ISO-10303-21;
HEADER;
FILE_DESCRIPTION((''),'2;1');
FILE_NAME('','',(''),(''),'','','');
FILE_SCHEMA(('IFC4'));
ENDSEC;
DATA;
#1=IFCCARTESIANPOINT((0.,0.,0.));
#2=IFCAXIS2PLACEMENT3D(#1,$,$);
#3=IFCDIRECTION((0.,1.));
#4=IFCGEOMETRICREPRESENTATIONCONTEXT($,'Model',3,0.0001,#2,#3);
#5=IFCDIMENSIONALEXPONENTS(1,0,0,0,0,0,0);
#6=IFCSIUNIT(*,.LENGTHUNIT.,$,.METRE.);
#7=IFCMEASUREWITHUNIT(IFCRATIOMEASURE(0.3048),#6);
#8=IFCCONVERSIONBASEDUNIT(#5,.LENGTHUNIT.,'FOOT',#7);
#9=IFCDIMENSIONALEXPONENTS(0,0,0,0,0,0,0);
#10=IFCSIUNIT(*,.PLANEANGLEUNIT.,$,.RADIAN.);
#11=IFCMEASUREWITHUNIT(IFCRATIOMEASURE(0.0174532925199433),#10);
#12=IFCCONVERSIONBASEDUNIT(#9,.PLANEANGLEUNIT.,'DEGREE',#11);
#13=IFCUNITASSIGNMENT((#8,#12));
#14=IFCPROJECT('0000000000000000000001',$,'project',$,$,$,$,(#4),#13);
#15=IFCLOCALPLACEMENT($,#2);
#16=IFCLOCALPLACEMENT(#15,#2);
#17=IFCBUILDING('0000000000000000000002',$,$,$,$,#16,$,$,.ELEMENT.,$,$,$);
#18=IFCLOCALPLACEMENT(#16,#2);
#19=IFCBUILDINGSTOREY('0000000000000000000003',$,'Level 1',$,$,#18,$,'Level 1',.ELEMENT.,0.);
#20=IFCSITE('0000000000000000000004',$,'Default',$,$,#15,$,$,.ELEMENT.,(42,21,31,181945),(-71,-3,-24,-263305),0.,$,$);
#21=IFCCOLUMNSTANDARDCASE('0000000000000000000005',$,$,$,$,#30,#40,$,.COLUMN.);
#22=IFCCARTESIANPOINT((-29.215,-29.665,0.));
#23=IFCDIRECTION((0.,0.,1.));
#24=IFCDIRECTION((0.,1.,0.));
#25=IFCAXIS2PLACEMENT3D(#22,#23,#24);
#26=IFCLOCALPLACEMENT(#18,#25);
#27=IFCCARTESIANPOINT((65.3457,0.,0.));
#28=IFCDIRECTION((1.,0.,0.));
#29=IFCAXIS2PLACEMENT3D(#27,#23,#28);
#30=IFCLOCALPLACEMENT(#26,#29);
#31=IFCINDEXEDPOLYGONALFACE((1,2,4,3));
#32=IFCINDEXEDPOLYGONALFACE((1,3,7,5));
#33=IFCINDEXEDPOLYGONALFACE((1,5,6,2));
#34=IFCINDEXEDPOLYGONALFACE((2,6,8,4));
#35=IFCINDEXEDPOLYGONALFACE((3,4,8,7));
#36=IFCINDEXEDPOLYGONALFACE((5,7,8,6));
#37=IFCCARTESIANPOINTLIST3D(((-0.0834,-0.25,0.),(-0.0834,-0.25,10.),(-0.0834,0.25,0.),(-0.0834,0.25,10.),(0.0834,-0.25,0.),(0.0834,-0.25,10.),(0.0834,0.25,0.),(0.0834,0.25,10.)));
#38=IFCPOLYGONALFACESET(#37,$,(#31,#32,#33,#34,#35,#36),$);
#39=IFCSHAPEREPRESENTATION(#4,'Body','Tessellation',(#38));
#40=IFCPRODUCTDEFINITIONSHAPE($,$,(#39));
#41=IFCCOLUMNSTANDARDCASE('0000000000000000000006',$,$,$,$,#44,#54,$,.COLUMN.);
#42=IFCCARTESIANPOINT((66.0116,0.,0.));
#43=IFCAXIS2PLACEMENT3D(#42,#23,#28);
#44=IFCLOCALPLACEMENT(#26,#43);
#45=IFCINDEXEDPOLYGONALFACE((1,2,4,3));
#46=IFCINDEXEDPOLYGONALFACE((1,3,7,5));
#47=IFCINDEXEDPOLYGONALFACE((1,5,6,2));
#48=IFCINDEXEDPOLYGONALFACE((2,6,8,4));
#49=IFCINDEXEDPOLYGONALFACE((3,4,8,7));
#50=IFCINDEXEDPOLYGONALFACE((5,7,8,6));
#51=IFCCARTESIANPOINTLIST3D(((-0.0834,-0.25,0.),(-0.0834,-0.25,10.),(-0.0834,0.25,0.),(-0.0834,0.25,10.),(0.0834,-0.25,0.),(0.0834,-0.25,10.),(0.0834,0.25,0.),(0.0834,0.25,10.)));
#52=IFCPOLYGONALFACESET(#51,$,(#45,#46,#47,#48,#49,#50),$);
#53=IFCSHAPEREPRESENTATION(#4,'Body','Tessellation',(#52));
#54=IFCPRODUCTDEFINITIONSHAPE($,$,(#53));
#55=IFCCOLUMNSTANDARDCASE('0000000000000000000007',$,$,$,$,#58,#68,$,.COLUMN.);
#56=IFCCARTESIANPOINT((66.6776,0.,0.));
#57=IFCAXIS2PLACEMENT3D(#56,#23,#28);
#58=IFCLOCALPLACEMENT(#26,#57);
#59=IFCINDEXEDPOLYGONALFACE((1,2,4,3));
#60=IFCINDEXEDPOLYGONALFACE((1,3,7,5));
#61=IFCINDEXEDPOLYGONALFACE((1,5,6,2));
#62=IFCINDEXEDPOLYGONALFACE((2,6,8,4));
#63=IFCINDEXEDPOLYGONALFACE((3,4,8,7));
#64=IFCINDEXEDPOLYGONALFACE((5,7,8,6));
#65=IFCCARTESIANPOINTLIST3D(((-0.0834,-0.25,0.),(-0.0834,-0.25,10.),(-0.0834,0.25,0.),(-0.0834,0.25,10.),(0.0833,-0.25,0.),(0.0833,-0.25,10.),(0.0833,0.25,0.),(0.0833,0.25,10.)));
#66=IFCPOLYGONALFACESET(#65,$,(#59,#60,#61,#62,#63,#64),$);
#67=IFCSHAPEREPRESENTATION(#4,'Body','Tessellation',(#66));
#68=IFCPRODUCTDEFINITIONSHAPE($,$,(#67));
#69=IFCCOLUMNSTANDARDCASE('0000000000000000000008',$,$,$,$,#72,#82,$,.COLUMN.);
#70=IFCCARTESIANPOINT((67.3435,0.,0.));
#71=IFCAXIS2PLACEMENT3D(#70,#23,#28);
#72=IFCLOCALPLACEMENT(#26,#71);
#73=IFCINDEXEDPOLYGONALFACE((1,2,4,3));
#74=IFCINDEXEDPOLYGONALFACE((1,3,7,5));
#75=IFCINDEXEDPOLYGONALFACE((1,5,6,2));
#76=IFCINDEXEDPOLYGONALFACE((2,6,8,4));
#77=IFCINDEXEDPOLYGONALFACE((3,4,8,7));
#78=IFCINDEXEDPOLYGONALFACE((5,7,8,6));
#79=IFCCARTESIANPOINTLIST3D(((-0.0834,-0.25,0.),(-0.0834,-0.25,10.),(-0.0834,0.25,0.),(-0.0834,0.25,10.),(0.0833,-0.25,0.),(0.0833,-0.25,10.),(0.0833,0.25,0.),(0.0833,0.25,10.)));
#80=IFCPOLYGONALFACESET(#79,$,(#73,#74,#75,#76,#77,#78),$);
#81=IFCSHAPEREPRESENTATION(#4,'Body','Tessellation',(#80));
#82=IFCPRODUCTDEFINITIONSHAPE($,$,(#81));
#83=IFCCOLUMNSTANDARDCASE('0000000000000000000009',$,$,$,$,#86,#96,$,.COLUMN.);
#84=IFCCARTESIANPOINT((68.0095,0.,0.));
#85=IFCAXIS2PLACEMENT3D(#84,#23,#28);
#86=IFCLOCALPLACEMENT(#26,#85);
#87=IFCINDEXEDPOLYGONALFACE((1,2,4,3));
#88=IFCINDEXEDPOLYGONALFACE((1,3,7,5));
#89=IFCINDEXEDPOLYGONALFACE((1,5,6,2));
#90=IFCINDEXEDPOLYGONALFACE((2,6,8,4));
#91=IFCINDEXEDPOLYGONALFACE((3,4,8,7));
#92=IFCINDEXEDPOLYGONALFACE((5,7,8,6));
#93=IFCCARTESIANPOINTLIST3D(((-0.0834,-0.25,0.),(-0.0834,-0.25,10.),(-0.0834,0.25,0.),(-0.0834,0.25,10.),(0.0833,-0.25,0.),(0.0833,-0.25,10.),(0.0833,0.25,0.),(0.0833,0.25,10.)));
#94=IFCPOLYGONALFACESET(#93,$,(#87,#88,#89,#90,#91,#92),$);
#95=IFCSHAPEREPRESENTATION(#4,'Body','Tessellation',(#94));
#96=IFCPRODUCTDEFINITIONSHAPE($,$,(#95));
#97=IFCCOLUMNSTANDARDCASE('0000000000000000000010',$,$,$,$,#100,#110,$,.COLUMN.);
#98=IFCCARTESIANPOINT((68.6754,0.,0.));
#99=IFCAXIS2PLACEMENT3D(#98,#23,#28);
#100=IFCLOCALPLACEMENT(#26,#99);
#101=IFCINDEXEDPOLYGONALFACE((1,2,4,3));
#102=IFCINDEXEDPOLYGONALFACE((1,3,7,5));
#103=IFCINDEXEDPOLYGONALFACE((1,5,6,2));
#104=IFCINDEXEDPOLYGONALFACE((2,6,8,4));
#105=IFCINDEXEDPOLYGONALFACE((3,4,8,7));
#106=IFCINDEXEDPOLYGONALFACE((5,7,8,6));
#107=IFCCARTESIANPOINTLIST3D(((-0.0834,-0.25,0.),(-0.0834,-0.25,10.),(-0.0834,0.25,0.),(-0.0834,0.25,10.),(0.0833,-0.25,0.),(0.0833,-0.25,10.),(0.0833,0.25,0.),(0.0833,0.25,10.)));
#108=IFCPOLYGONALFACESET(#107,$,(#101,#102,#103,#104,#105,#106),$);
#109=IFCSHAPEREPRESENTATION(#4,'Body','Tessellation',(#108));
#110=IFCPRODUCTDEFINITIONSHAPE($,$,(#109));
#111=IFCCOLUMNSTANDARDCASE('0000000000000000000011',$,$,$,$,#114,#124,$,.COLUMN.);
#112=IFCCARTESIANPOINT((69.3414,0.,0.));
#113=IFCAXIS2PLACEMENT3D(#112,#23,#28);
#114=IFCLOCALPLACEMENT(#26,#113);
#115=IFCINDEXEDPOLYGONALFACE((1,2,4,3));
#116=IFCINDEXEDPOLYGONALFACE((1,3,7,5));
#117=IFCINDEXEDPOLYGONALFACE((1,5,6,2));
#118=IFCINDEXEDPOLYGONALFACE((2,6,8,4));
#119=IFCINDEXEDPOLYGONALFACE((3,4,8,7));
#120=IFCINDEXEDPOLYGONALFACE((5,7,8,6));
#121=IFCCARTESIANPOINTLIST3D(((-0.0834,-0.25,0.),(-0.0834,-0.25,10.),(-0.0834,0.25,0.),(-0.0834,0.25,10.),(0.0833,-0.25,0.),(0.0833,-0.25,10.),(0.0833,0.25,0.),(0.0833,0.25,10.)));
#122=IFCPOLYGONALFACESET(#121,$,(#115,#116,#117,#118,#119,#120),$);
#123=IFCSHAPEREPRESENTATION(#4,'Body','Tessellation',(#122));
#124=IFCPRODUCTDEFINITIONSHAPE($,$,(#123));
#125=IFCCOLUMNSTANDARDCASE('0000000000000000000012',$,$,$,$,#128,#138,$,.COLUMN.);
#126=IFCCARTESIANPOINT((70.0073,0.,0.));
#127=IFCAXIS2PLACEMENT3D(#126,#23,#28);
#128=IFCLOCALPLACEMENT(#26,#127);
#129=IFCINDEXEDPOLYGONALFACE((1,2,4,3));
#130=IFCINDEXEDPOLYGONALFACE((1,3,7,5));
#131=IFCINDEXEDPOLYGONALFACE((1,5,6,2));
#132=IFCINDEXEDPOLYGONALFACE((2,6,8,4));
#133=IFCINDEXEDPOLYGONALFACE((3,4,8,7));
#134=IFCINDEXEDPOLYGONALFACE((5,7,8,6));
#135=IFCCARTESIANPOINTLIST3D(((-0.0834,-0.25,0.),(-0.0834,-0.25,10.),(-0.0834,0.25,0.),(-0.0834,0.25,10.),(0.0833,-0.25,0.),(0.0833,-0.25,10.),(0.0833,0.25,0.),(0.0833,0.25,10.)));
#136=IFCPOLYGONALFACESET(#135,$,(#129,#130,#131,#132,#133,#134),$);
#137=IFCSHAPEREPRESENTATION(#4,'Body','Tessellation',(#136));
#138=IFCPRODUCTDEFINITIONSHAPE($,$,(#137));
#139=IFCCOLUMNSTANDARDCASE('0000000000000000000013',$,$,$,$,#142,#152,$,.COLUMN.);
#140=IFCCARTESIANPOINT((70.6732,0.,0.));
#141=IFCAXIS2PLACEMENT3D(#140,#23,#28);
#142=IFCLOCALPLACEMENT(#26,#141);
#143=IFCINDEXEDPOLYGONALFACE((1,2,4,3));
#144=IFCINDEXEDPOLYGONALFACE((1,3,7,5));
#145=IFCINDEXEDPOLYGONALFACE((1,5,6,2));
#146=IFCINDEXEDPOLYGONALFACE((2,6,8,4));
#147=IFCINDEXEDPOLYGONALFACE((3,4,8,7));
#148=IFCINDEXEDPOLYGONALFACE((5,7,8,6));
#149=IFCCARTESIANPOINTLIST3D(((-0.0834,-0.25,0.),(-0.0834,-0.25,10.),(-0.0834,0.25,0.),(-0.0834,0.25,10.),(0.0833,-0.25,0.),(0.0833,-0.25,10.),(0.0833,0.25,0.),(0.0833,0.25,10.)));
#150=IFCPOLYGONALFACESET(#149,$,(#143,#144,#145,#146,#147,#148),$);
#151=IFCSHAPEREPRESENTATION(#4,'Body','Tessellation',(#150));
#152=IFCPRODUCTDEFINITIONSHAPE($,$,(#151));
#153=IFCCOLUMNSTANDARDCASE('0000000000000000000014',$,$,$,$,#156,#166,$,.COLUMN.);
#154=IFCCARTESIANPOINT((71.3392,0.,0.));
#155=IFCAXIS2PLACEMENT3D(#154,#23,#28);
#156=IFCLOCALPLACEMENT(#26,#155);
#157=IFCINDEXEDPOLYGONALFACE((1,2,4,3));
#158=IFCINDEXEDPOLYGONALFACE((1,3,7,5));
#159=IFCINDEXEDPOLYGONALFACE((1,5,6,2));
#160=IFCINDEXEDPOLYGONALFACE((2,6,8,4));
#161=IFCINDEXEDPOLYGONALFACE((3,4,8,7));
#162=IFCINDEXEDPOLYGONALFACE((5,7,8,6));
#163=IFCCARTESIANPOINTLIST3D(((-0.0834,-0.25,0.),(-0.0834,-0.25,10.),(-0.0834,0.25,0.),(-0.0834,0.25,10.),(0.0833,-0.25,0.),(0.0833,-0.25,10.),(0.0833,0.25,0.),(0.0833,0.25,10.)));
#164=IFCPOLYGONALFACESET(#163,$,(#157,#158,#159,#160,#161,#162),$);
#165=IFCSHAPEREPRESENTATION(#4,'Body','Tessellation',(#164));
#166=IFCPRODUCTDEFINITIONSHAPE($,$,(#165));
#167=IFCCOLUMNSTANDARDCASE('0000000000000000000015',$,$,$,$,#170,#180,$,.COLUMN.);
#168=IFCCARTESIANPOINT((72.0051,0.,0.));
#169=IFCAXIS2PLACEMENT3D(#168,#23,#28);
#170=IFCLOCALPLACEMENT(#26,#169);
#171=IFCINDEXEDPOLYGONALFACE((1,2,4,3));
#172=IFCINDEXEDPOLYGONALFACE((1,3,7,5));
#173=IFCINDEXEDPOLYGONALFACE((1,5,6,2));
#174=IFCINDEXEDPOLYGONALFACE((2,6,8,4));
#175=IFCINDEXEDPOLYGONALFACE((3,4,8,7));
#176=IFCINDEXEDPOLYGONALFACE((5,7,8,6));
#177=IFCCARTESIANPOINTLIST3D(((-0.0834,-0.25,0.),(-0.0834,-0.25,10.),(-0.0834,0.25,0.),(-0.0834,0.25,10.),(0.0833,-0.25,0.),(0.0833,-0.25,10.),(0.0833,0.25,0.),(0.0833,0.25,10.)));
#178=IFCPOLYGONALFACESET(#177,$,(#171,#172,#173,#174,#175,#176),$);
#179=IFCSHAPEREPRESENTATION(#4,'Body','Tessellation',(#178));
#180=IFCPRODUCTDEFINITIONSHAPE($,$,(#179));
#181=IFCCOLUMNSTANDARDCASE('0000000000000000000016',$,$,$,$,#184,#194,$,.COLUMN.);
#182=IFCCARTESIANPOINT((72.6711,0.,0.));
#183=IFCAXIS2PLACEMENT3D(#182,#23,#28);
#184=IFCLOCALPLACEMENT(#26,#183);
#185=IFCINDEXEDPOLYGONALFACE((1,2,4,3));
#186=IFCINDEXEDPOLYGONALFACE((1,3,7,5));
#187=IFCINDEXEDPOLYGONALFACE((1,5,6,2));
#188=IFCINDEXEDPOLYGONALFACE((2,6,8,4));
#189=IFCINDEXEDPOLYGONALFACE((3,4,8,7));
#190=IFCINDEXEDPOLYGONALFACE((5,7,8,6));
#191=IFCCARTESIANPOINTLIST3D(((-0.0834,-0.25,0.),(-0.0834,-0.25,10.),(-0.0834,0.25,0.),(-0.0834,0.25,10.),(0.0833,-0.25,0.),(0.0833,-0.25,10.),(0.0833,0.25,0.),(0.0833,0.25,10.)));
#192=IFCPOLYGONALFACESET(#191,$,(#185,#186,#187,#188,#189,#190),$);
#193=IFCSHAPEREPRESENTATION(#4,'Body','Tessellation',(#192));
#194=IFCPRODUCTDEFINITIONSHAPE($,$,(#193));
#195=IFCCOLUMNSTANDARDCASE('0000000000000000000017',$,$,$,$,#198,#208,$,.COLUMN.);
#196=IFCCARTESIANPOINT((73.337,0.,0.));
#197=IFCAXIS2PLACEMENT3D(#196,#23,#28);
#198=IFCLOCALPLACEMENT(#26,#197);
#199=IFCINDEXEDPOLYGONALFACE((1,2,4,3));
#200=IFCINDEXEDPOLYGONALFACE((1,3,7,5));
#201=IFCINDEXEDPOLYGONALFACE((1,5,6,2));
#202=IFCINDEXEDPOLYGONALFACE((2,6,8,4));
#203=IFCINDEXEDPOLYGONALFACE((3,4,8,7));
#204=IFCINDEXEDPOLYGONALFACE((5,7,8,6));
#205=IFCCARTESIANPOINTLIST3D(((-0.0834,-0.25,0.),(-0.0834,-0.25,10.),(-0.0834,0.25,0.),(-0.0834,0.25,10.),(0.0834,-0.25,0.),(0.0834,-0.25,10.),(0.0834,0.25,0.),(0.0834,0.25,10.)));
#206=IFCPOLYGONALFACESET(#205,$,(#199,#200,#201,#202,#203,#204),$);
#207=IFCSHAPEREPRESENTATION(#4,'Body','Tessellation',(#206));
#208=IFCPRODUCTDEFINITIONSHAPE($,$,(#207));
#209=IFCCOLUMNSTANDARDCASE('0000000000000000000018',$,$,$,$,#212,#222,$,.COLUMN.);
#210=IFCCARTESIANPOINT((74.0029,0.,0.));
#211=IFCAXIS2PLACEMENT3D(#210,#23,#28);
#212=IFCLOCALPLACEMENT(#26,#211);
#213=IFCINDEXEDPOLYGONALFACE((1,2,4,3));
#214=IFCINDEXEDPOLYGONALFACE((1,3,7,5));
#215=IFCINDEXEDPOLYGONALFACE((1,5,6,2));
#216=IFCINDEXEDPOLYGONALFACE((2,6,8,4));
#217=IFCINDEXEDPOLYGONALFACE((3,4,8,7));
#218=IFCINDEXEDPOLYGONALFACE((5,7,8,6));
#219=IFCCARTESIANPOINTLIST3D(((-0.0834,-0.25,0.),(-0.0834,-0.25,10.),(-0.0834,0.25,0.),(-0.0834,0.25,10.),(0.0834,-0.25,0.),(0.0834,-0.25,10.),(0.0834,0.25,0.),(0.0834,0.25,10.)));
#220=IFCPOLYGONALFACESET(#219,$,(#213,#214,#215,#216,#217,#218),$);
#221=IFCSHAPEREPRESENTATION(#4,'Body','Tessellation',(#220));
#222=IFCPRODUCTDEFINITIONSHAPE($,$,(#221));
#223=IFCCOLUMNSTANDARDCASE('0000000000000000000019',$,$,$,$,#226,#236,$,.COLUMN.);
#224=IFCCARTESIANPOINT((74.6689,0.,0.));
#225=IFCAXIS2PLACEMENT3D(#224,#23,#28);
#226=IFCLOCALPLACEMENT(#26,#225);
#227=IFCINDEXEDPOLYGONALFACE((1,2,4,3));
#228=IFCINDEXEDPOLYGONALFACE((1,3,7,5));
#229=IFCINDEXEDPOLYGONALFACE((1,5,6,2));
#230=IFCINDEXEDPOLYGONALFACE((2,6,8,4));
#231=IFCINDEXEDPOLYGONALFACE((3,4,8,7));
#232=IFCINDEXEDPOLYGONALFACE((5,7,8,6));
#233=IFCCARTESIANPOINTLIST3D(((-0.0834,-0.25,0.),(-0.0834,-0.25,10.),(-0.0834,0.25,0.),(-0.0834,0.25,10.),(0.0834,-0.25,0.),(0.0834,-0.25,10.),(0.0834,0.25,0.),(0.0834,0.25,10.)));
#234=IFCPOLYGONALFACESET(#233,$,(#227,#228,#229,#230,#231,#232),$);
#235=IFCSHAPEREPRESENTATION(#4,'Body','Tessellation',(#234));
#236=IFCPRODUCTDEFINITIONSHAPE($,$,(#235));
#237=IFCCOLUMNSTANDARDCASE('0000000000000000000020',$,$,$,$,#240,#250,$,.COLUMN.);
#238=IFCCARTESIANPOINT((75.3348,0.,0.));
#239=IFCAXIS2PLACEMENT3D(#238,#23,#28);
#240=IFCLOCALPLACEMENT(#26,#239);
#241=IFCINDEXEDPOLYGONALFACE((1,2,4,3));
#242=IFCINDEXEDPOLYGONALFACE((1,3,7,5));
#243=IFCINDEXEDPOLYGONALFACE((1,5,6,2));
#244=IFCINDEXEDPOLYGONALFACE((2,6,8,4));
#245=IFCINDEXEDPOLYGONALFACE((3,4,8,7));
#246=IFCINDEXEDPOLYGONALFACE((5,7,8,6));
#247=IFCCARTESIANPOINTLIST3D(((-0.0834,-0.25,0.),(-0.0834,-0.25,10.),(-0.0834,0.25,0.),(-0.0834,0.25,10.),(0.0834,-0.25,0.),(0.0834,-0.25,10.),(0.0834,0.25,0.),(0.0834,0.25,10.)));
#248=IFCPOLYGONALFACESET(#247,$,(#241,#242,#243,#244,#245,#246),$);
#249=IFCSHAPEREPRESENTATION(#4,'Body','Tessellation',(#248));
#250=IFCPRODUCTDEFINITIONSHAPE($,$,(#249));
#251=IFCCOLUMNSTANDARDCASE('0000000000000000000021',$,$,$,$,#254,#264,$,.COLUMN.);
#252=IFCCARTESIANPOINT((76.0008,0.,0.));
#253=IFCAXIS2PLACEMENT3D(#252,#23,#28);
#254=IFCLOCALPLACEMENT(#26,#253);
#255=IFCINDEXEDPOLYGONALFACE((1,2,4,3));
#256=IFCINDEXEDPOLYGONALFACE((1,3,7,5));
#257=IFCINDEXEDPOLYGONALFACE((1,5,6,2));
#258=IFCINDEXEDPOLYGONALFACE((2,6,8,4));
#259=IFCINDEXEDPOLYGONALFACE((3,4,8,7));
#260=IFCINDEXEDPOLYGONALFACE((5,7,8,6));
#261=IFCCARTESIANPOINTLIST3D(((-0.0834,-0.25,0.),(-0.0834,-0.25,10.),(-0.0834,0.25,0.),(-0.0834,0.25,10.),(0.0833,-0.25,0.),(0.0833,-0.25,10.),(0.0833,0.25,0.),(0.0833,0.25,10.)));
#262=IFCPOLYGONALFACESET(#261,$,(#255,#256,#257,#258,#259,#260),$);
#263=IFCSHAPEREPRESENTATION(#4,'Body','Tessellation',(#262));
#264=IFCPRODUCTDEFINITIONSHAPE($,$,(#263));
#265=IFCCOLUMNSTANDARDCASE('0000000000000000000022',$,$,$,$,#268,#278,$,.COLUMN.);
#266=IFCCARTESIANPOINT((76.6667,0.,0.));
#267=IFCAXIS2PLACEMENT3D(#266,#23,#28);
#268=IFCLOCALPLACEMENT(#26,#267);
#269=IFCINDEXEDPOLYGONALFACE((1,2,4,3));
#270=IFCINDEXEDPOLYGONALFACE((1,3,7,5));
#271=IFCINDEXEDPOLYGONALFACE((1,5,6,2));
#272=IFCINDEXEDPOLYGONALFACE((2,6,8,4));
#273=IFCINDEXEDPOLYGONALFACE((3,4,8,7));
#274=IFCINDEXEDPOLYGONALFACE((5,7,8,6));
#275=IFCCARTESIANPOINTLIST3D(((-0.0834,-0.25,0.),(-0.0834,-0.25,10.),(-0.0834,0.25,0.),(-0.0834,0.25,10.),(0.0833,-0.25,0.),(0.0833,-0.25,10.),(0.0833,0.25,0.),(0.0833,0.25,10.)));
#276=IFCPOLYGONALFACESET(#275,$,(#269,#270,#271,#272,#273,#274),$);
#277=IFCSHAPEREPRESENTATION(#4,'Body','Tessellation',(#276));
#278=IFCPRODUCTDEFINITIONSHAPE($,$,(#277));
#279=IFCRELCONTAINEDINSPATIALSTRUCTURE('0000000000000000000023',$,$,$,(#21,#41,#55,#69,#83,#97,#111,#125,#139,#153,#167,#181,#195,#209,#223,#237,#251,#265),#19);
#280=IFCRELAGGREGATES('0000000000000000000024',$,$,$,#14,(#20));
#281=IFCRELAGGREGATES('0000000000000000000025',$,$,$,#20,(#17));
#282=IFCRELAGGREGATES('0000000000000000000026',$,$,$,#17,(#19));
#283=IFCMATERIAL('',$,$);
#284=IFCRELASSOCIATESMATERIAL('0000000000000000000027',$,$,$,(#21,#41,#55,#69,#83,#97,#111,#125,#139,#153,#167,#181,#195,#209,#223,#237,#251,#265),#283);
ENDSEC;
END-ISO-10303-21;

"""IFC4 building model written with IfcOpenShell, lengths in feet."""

from ifc_helpers import new_model, entity, si_unit, converted_unit, direction, frame, origin, place, context, project, spatial, rectangle, extrude, material, element, save


model = new_model("IFC4")

# Units and contexts
model_context = context("Model", 3, precision=0.0001, world=origin(), true_north=direction((0.0, 1.0)))
ifc_project = project(units=[converted_unit("LENGTHUNIT", "FOOT", entity("IfcRatioMeasure", 0.3048), si_unit("LENGTHUNIT", "METRE"), dimensions=[1, 0, 0, 0, 0, 0, 0]), converted_unit("PLANEANGLEUNIT", "DEGREE", entity("IfcRatioMeasure", 0.0174532925199433), si_unit("PLANEANGLEUNIT", "RADIAN"), dimensions=[0, 0, 0, 0, 0, 0, 0])], contexts=[model_context])

# Site, building, storey
site_placement = place(None, origin())
site = spatial("IfcSite", under=ifc_project, at=site_placement, Name="Default", CompositionType="ELEMENT", RefLatitude=(42, 21, 31, 181945), RefLongitude=(-71, -3, -24, -263305), RefElevation=0.0)
building_placement = place(site_placement, origin())
building = spatial("IfcBuilding", under=site, at=building_placement, CompositionType="ELEMENT")
storey_placement = place(building_placement, origin())
storey = spatial("IfcBuildingStorey", under=building, at=storey_placement, Name="Level 1", LongName="Level 1", CompositionType="ELEMENT", Elevation=0.0)

# Columns
ifc_material_1 = material(Name="")
placement = place(storey_placement, frame((-29.215, -29.665, 0.0), z_axis=(0.0, 0.0, 1.0), x_axis=(0.0, 1.0, 0.0)))
for number, where, z_axis, x_axis in (
    (1, (65.3457, 0.0, 0.0), (0.0, 0.0, 1.0), (1.0, 0.0, 0.0)),
    (2, (66.0116, 0.0, 0.0), (0.0, 0.0, 1.0), (1.0, 0.0, 0.0)),
    (3, (66.6776, 0.0, 0.0), (0.0, 0.0, 1.0), (1.0, 0.0, 0.0)),
    (4, (67.3435, 0.0, 0.0), (0.0, 0.0, 1.0), (1.0, 0.0, 0.0)),
    (5, (68.0095, 0.0, 0.0), (0.0, 0.0, 1.0), (1.0, 0.0, 0.0)),
    (6, (68.6754, 0.0, 0.0), (0.0, 0.0, 1.0), (1.0, 0.0, 0.0)),
    (7, (69.3414, 0.0, 0.0), (0.0, 0.0, 1.0), (1.0, 0.0, 0.0)),
    (8, (70.0073, 0.0, 0.0), (0.0, 0.0, 1.0), (1.0, 0.0, 0.0)),
    (9, (70.6732, 0.0, 0.0), (0.0, 0.0, 1.0), (1.0, 0.0, 0.0)),
    (10, (71.3392, 0.0, 0.0), (0.0, 0.0, 1.0), (1.0, 0.0, 0.0)),
    (11, (72.0051, 0.0, 0.0), (0.0, 0.0, 1.0), (1.0, 0.0, 0.0)),
    (12, (72.6711, 0.0, 0.0), (0.0, 0.0, 1.0), (1.0, 0.0, 0.0)),
    (13, (73.337, 0.0, 0.0), (0.0, 0.0, 1.0), (1.0, 0.0, 0.0)),
    (14, (74.0029, 0.0, 0.0), (0.0, 0.0, 1.0), (1.0, 0.0, 0.0)),
    (15, (74.6689, 0.0, 0.0), (0.0, 0.0, 1.0), (1.0, 0.0, 0.0)),
    (16, (75.3348, 0.0, 0.0), (0.0, 0.0, 1.0), (1.0, 0.0, 0.0)),
    (17, (76.0008, 0.0, 0.0), (0.0, 0.0, 1.0), (1.0, 0.0, 0.0)),
    (18, (76.6667, 0.0, 0.0), (0.0, 0.0, 1.0), (1.0, 0.0, 0.0)),
):
    element("IfcColumnStandardCase", number, at=place(placement, frame(where, z_axis=z_axis, x_axis=x_axis)), inside=storey, material=ifc_material_1, PredefinedType="COLUMN", context=model_context, shape_type="SweptSolid", body=[
        extrude(rectangle(XDim=0.1667, YDim=0.5), origin(), (0.0, 0.0, 1.0), 10.0),
    ])

save(model, "model.ifc")
